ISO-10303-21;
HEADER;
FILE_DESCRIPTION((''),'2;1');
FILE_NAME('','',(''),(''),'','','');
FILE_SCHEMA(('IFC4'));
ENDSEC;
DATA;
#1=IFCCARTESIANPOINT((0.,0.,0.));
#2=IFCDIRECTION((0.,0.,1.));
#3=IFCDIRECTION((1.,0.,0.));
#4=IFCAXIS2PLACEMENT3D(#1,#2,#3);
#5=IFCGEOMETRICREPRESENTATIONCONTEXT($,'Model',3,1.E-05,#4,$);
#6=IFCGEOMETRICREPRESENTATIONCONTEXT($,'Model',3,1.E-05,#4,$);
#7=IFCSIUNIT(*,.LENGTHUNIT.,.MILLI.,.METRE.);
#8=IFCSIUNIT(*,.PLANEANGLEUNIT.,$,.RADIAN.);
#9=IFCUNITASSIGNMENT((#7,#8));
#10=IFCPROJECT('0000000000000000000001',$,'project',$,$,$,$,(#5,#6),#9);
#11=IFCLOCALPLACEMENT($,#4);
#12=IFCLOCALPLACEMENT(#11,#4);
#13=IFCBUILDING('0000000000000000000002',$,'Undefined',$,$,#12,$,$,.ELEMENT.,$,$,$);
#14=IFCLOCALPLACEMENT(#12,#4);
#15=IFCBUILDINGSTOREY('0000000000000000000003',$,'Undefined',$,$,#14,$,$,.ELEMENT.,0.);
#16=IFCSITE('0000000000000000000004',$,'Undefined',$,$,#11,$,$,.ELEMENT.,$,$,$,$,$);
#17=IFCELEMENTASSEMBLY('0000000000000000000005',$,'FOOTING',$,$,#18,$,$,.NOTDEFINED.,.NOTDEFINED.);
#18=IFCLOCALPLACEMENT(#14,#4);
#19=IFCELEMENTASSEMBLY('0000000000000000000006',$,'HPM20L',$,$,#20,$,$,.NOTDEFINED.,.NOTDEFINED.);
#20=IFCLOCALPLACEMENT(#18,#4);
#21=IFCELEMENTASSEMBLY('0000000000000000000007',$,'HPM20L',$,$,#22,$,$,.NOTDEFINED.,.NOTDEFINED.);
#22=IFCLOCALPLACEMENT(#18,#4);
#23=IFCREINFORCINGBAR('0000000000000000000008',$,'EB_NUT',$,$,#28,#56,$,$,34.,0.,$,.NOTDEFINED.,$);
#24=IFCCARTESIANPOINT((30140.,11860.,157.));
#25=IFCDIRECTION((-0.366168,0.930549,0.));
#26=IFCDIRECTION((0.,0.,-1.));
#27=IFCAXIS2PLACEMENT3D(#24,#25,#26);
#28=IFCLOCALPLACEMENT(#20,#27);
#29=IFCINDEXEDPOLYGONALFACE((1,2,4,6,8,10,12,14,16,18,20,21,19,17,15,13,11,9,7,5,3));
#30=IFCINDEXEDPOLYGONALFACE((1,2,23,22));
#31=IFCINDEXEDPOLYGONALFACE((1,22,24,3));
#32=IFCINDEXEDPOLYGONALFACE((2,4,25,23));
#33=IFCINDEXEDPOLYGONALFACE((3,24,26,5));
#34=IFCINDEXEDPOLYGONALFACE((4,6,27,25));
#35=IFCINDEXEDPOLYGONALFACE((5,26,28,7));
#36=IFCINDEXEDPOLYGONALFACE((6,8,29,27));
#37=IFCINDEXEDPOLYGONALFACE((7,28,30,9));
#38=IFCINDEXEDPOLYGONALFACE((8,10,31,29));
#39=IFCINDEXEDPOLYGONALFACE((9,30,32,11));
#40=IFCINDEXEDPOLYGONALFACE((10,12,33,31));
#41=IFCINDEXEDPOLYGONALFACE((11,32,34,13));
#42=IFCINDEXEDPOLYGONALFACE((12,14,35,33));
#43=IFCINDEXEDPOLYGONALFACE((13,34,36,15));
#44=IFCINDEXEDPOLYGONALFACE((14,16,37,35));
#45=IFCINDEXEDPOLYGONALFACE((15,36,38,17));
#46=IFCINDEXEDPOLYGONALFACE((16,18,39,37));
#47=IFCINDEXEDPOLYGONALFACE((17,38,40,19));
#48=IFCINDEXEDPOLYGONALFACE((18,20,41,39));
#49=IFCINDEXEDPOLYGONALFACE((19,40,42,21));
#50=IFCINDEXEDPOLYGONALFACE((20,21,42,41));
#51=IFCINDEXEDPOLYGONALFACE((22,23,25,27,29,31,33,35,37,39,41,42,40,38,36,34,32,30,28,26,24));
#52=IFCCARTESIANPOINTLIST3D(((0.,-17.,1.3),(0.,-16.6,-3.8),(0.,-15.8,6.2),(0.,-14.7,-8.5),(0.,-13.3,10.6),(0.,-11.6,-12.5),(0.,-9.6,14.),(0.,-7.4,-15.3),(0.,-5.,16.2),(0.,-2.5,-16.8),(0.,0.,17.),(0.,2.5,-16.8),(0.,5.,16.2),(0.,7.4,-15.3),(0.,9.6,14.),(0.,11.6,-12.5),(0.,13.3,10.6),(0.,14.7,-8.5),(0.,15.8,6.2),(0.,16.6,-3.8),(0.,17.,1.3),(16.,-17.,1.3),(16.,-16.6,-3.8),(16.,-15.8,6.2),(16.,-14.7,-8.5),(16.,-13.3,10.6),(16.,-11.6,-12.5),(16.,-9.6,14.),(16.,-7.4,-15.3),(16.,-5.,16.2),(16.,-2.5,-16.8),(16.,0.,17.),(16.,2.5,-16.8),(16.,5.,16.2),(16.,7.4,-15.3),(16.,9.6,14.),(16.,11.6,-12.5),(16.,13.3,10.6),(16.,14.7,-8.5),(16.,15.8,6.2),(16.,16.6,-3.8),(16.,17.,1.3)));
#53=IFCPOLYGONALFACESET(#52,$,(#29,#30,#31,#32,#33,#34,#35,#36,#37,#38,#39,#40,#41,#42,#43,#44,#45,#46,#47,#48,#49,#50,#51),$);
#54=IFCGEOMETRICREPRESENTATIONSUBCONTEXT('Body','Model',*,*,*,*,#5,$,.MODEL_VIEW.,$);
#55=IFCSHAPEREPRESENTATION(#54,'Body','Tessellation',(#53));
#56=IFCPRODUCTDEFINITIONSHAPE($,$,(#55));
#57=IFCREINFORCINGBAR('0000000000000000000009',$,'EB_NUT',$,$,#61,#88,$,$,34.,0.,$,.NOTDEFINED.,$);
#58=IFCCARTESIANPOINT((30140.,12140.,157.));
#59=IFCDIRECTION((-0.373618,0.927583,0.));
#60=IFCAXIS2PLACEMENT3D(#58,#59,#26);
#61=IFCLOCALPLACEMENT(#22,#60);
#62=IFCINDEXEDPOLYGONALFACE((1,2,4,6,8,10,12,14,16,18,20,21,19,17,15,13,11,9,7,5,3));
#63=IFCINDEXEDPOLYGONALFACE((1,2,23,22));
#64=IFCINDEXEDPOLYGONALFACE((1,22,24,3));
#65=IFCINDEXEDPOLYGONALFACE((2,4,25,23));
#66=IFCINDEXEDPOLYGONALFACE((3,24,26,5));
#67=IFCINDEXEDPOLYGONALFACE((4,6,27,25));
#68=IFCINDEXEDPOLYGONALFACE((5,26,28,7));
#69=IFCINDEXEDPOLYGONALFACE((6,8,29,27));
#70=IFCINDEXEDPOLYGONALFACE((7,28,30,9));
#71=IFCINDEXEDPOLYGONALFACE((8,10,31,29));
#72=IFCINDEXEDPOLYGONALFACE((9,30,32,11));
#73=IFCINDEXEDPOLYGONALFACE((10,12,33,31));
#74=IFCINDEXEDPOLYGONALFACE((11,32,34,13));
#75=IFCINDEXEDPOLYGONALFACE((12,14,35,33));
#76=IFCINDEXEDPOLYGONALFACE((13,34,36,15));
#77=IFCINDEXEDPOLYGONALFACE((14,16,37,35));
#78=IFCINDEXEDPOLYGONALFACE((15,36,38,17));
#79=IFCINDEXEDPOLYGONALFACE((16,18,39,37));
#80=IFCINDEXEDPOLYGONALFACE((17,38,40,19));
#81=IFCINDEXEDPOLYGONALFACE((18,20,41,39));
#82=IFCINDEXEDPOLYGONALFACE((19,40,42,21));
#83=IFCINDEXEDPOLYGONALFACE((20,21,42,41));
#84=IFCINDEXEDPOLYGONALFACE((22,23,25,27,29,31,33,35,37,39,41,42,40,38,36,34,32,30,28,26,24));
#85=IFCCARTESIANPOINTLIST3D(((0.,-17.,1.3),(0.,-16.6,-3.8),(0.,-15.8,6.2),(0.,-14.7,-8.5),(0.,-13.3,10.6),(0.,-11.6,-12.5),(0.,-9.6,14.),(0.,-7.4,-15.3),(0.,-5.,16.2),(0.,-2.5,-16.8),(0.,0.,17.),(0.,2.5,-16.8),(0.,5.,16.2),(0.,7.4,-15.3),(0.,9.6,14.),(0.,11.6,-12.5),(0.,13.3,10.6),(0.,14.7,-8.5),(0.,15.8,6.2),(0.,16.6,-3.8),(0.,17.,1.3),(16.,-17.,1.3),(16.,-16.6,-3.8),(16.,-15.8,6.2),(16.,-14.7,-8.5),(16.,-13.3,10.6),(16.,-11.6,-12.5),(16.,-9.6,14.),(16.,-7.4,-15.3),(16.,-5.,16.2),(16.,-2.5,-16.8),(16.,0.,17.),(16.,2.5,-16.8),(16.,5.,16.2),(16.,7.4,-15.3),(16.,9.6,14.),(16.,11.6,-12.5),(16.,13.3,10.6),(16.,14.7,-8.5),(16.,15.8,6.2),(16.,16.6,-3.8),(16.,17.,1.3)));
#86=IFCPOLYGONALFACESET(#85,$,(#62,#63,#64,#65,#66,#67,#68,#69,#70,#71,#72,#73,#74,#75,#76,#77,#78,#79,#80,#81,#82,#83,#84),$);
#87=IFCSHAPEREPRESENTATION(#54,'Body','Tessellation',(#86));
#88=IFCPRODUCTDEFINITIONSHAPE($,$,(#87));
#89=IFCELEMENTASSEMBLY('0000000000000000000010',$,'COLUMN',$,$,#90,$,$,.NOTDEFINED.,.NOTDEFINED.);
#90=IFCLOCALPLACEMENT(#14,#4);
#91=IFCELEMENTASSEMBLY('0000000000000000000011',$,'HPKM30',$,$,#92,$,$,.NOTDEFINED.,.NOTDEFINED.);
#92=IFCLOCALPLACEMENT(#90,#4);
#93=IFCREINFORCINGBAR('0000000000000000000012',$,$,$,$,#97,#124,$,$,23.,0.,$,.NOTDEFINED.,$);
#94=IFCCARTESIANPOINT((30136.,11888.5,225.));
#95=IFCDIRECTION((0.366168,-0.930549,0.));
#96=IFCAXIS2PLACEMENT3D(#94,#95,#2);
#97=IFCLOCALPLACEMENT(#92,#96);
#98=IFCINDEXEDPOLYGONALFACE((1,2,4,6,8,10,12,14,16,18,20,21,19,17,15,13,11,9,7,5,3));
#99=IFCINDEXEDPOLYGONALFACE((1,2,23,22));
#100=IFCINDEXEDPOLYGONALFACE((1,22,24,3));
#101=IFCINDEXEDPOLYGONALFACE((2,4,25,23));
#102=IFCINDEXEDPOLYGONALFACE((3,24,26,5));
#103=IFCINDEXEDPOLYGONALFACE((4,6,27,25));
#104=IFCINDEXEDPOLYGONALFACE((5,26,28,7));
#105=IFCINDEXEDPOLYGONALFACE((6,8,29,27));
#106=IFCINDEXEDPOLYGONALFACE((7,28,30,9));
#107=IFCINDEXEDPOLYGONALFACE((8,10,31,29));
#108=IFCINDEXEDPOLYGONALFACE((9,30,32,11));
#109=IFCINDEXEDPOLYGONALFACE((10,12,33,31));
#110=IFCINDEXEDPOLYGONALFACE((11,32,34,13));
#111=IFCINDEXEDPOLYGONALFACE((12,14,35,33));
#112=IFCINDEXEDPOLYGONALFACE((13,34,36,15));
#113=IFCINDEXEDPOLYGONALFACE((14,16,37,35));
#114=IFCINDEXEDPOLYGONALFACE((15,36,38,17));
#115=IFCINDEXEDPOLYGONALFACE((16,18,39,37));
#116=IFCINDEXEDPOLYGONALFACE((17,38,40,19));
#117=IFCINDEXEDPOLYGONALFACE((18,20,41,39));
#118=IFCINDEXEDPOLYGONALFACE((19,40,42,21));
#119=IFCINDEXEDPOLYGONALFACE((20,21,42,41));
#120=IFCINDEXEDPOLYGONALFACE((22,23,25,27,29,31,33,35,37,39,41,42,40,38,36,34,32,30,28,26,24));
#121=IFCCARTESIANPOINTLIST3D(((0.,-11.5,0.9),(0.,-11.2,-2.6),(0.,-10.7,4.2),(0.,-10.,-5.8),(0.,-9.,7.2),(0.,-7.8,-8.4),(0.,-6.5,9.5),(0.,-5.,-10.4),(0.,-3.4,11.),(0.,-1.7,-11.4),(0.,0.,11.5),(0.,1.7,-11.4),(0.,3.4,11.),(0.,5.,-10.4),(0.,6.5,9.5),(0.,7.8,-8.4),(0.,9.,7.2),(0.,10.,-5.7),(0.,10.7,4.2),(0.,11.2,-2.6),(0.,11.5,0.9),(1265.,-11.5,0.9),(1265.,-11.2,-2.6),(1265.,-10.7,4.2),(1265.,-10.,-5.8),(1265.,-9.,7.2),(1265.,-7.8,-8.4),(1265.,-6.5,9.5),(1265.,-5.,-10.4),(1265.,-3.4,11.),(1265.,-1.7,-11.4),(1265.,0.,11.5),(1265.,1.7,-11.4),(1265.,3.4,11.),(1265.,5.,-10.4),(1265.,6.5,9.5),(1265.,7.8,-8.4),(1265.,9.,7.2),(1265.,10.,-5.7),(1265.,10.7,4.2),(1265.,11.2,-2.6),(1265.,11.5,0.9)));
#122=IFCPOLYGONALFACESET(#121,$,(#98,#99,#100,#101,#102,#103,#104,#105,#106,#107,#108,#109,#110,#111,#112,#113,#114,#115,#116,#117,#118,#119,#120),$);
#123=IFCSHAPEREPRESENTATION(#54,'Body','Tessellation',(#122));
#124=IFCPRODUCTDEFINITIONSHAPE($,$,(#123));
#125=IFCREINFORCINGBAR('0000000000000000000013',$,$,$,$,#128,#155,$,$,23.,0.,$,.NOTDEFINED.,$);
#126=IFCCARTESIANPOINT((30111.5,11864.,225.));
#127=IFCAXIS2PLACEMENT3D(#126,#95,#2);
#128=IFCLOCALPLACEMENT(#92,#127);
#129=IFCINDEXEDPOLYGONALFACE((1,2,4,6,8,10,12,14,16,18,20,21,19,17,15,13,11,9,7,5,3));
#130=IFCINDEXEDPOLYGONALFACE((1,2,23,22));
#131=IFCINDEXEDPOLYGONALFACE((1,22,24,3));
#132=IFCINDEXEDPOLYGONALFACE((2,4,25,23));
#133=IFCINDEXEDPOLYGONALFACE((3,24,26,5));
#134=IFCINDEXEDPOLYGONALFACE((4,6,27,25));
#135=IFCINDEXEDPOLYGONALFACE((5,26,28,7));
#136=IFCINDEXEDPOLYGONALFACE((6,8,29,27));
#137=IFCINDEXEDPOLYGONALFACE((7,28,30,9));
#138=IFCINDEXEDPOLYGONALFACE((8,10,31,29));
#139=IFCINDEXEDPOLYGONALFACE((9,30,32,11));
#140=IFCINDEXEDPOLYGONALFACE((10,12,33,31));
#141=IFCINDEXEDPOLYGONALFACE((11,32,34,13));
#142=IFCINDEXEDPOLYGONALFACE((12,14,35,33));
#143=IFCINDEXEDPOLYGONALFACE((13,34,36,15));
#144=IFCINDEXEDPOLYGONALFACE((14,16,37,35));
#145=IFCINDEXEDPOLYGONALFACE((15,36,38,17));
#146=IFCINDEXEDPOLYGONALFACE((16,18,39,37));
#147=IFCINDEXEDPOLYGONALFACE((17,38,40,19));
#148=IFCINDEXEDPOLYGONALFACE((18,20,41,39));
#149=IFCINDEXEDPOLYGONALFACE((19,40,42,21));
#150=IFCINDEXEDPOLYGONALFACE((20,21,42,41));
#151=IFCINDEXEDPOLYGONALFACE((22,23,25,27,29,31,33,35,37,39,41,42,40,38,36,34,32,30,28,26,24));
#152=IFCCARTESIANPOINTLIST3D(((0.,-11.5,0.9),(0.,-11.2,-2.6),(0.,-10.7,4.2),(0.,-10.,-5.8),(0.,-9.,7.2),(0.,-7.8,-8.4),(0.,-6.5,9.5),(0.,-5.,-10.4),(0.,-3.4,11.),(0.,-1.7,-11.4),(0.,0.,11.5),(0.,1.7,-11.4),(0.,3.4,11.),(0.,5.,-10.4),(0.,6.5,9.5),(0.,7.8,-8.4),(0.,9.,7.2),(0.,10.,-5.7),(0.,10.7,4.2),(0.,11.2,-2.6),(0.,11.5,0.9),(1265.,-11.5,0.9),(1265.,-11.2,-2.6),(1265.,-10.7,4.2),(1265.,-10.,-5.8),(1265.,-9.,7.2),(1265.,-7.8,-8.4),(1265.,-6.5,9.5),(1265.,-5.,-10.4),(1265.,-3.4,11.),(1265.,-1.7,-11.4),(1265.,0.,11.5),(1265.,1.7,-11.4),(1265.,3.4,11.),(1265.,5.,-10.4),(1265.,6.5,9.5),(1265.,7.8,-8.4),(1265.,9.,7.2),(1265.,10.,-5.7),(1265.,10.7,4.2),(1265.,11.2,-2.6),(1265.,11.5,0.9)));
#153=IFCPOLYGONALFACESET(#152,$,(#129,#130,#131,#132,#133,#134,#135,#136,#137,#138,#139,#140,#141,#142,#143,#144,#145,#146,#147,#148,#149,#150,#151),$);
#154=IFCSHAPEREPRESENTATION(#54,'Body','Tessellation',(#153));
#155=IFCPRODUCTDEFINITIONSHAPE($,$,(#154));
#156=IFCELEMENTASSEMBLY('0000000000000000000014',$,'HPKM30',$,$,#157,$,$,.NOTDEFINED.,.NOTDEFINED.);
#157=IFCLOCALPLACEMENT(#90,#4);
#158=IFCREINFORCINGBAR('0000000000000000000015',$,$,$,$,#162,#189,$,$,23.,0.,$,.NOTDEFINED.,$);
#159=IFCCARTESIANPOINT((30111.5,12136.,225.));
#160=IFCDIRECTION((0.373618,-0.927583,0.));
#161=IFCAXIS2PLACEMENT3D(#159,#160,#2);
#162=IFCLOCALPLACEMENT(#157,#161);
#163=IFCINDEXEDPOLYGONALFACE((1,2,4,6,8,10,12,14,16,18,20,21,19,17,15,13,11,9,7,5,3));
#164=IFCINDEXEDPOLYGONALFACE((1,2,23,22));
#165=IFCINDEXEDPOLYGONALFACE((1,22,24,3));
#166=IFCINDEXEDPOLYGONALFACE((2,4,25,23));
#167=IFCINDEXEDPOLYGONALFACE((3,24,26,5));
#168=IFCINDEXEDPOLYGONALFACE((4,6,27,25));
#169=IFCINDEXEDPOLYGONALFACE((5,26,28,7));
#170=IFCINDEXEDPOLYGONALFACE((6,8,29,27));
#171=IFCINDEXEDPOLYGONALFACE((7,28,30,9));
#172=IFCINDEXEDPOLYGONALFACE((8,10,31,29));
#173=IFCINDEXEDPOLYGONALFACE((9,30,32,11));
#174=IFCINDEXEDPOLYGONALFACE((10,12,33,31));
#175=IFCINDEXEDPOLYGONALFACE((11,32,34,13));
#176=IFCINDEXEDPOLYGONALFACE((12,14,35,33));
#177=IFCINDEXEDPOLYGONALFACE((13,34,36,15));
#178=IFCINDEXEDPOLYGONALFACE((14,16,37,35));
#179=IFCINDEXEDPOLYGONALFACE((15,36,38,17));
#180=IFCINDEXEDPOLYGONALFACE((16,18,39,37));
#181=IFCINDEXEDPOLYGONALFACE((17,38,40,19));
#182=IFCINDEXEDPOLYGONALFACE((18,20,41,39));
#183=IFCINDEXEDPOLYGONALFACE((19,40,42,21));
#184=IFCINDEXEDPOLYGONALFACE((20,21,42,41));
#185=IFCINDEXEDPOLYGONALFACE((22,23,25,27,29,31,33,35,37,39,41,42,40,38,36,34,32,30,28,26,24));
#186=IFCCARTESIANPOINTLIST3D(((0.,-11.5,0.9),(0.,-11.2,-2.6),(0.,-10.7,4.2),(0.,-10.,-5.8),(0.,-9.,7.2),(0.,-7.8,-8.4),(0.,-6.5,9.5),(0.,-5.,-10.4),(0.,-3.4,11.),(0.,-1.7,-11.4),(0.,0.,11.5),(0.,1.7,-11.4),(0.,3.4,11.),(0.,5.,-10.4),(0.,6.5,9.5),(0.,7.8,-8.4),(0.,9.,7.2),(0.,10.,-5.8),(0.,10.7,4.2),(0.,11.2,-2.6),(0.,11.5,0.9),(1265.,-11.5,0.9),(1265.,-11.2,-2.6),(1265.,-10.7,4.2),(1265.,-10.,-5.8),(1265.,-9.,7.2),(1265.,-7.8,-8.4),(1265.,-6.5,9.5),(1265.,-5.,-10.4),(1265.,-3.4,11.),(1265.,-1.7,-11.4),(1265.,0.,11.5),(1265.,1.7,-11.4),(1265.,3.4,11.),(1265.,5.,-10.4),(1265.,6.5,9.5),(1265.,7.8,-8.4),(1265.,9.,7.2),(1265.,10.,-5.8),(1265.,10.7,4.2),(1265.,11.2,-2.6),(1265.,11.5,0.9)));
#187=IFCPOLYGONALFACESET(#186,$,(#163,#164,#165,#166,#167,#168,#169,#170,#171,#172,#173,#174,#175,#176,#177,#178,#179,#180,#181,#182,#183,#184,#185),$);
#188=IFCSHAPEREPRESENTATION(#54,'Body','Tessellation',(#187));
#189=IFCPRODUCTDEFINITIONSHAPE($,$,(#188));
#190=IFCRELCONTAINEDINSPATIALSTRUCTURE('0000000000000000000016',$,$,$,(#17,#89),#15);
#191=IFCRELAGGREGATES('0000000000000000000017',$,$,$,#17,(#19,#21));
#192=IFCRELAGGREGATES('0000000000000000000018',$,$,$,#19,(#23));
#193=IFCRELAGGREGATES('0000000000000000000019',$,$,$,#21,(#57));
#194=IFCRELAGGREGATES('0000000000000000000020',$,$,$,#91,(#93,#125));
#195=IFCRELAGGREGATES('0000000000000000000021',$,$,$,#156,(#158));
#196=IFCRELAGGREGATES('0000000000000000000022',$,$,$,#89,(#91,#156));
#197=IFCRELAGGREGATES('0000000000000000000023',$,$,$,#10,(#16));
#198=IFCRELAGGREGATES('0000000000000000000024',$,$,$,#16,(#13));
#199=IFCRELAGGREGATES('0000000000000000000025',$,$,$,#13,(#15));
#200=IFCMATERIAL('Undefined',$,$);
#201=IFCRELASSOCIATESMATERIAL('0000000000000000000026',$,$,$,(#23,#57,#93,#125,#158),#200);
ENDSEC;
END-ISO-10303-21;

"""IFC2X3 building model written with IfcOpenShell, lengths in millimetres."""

from ifc_helpers import new_model, entity, si_unit, frame, origin_with_axes, place, context, subcontext, project, spatial, source, transform, mapped, material, element, aggregate, save


model = new_model("IFC2X3")

# Units and contexts
model_context_1 = context("Model", 3, precision=1e-05, world=origin_with_axes())
model_context_2 = context("Model", 3, precision=1e-05, world=origin_with_axes())
body_context = subcontext(model_context_1, "Body", "Model", "MODEL_VIEW")
ifc_project = project(units=[si_unit("LENGTHUNIT", "METRE", prefix="MILLI"), si_unit("PLANEANGLEUNIT", "RADIAN")], contexts=[model_context_1, model_context_2])

# Site, building, storey
site_placement = place(None, origin_with_axes())
site = spatial("IfcSite", under=ifc_project, at=site_placement, Name="Undefined", CompositionType="ELEMENT")
building_placement = place(site_placement, origin_with_axes())
building = spatial("IfcBuilding", under=site, at=building_placement, Name="Undefined", CompositionType="ELEMENT")
storey_placement = place(building_placement, origin_with_axes())
storey = spatial("IfcBuildingStorey", under=building, at=storey_placement, Name="Undefined", CompositionType="ELEMENT", Elevation=0.0)

# Element assemblies
assembly_1_placement = place(storey_placement, origin_with_axes())
assembly_1 = element("IfcElementAssembly", 1, at=assembly_1_placement, inside=storey, Name="FOOTING", AssemblyPlace="NOTDEFINED", PredefinedType="NOTDEFINED")
assembly_2_placement = place(assembly_1_placement, origin_with_axes())
assembly_2 = element("IfcElementAssembly", 2, at=assembly_2_placement, Name="HPM20L", AssemblyPlace="NOTDEFINED", PredefinedType="NOTDEFINED")
assembly_3_placement = place(assembly_1_placement, origin_with_axes())
assembly_3 = element("IfcElementAssembly", 3, at=assembly_3_placement, Name="HPM20L", AssemblyPlace="NOTDEFINED", PredefinedType="NOTDEFINED")
aggregate(assembly_1, [assembly_2, assembly_3])

# Shared definitions
ifc_material_1 = material(Name="Undefined")

# Reinforcing bars
shared_shape_1 = source(origin_with_axes(), body_context, "Body", "AdvancedSweptSolid", [
    entity("IfcSweptDiskSolid", entity("IfcTrimmedCurve", entity("IfcLine", entity("IfcCartesianPoint", [0.0, 0.0, 0.0]), entity("IfcVector", entity("IfcDirection", [1.0, 0.0, 0.0]), 1.0)), [entity("IfcParameterValue", 0.0)], [entity("IfcParameterValue", 16.0)], True, "PARAMETER"), 17.0, None, 0.0, 16.0),
])
reinforcing_bar_1_placement = place(assembly_2_placement, frame((30140.0, 11860.0, 157.0), z_axis=(-0.366168, 0.930549, 0.0), x_axis=(0.0, 0.0, -1.0)))
reinforcing_bar_1 = element("IfcReinforcingBar", 4, at=reinforcing_bar_1_placement, material=ifc_material_1, Name="EB_NUT", BarRole="NOTDEFINED", CrossSectionArea=0.0, NominalDiameter=34.0, context=body_context, shape_type="MappedRepresentation", body=[
    mapped(shared_shape_1, transform((0.0, 0.0, 0.0))),
])
aggregate(assembly_2, [reinforcing_bar_1])
shared_shape_2 = source(origin_with_axes(), body_context, "Body", "AdvancedSweptSolid", [
    entity("IfcSweptDiskSolid", entity("IfcTrimmedCurve", entity("IfcLine", entity("IfcCartesianPoint", [0.0, 0.0, 0.0]), entity("IfcVector", entity("IfcDirection", [1.0, 0.0, 0.0]), 1.0)), [entity("IfcParameterValue", 0.0)], [entity("IfcParameterValue", 16.0)], True, "PARAMETER"), 17.0, None, 0.0, 16.0),
])
reinforcing_bar_2_placement = place(assembly_3_placement, frame((30140.0, 12140.0, 157.0), z_axis=(-0.373618, 0.927583, 0.0), x_axis=(0.0, 0.0, -1.0)))
reinforcing_bar_2 = element("IfcReinforcingBar", 5, at=reinforcing_bar_2_placement, material=ifc_material_1, Name="EB_NUT", BarRole="NOTDEFINED", CrossSectionArea=0.0, NominalDiameter=34.0, context=body_context, shape_type="MappedRepresentation", body=[
    mapped(shared_shape_2, transform((0.0, 0.0, 0.0))),
])
aggregate(assembly_3, [reinforcing_bar_2])

# Element assemblies, reinforcing bars
assembly_4_placement = place(storey_placement, origin_with_axes())
assembly_4 = element("IfcElementAssembly", 6, at=assembly_4_placement, inside=storey, Name="COLUMN", AssemblyPlace="NOTDEFINED", PredefinedType="NOTDEFINED")
assembly_5_placement = place(assembly_4_placement, origin_with_axes())
assembly_5 = element("IfcElementAssembly", 7, at=assembly_5_placement, Name="HPKM30", AssemblyPlace="NOTDEFINED", PredefinedType="NOTDEFINED")
shared_shape_3 = source(origin_with_axes(), body_context, "Body", "AdvancedSweptSolid", [
    entity("IfcSweptDiskSolid", entity("IfcTrimmedCurve", entity("IfcLine", entity("IfcCartesianPoint", [0.0, 0.0, 0.0]), entity("IfcVector", entity("IfcDirection", [1.0, 0.0, 0.0]), 1.0)), [entity("IfcParameterValue", 0.0)], [entity("IfcParameterValue", 1265.0)], True, "PARAMETER"), 11.5, None, 0.0, 1265.0),
])
reinforcing_bar_3_placement = place(assembly_5_placement, frame((30136.0, 11888.5, 225.0), z_axis=(0.366168, -0.930549, 0.0), x_axis=(0.0, 0.0, 1.0)))
reinforcing_bar_3 = element("IfcReinforcingBar", 8, at=reinforcing_bar_3_placement, material=ifc_material_1, BarRole="NOTDEFINED", CrossSectionArea=0.0, NominalDiameter=23.0, context=body_context, shape_type="MappedRepresentation", body=[
    mapped(shared_shape_3, transform((0.0, 0.0, 0.0))),
])
shared_shape_4 = source(origin_with_axes(), body_context, "Body", "AdvancedSweptSolid", [
    entity("IfcSweptDiskSolid", entity("IfcTrimmedCurve", entity("IfcLine", entity("IfcCartesianPoint", [0.0, 0.0, 0.0]), entity("IfcVector", entity("IfcDirection", [1.0, 0.0, 0.0]), 1.0)), [entity("IfcParameterValue", 0.0)], [entity("IfcParameterValue", 1265.0)], True, "PARAMETER"), 11.5, None, 0.0, 1265.0),
])
reinforcing_bar_4_placement = place(assembly_5_placement, frame((30111.5, 11864.0, 225.0), z_axis=(0.366168, -0.930549, 0.0), x_axis=(0.0, 0.0, 1.0)))
reinforcing_bar_4 = element("IfcReinforcingBar", 9, at=reinforcing_bar_4_placement, material=ifc_material_1, BarRole="NOTDEFINED", CrossSectionArea=0.0, NominalDiameter=23.0, context=body_context, shape_type="MappedRepresentation", body=[
    mapped(shared_shape_4, transform((0.0, 0.0, 0.0))),
])
aggregate(assembly_5, [reinforcing_bar_3, reinforcing_bar_4])
assembly_6_placement = place(assembly_4_placement, origin_with_axes())
assembly_6 = element("IfcElementAssembly", 10, at=assembly_6_placement, Name="HPKM30", AssemblyPlace="NOTDEFINED", PredefinedType="NOTDEFINED")
shared_shape_5 = source(origin_with_axes(), body_context, "Body", "AdvancedSweptSolid", [
    entity("IfcSweptDiskSolid", entity("IfcTrimmedCurve", entity("IfcLine", entity("IfcCartesianPoint", [0.0, 0.0, 0.0]), entity("IfcVector", entity("IfcDirection", [1.0, 0.0, 0.0]), 1.0)), [entity("IfcParameterValue", 0.0)], [entity("IfcParameterValue", 1265.0)], True, "PARAMETER"), 11.5, None, 0.0, 1265.0),
])
reinforcing_bar_5_placement = place(assembly_6_placement, frame((30111.5, 12136.0, 225.0), z_axis=(0.373618, -0.927583, 0.0), x_axis=(0.0, 0.0, 1.0)))
reinforcing_bar_5 = element("IfcReinforcingBar", 11, at=reinforcing_bar_5_placement, material=ifc_material_1, BarRole="NOTDEFINED", CrossSectionArea=0.0, NominalDiameter=23.0, context=body_context, shape_type="MappedRepresentation", body=[
    mapped(shared_shape_5, transform((0.0, 0.0, 0.0))),
])
aggregate(assembly_6, [reinforcing_bar_5])

aggregate(assembly_4, [assembly_5, assembly_6])

save(model, "model.ifc")
